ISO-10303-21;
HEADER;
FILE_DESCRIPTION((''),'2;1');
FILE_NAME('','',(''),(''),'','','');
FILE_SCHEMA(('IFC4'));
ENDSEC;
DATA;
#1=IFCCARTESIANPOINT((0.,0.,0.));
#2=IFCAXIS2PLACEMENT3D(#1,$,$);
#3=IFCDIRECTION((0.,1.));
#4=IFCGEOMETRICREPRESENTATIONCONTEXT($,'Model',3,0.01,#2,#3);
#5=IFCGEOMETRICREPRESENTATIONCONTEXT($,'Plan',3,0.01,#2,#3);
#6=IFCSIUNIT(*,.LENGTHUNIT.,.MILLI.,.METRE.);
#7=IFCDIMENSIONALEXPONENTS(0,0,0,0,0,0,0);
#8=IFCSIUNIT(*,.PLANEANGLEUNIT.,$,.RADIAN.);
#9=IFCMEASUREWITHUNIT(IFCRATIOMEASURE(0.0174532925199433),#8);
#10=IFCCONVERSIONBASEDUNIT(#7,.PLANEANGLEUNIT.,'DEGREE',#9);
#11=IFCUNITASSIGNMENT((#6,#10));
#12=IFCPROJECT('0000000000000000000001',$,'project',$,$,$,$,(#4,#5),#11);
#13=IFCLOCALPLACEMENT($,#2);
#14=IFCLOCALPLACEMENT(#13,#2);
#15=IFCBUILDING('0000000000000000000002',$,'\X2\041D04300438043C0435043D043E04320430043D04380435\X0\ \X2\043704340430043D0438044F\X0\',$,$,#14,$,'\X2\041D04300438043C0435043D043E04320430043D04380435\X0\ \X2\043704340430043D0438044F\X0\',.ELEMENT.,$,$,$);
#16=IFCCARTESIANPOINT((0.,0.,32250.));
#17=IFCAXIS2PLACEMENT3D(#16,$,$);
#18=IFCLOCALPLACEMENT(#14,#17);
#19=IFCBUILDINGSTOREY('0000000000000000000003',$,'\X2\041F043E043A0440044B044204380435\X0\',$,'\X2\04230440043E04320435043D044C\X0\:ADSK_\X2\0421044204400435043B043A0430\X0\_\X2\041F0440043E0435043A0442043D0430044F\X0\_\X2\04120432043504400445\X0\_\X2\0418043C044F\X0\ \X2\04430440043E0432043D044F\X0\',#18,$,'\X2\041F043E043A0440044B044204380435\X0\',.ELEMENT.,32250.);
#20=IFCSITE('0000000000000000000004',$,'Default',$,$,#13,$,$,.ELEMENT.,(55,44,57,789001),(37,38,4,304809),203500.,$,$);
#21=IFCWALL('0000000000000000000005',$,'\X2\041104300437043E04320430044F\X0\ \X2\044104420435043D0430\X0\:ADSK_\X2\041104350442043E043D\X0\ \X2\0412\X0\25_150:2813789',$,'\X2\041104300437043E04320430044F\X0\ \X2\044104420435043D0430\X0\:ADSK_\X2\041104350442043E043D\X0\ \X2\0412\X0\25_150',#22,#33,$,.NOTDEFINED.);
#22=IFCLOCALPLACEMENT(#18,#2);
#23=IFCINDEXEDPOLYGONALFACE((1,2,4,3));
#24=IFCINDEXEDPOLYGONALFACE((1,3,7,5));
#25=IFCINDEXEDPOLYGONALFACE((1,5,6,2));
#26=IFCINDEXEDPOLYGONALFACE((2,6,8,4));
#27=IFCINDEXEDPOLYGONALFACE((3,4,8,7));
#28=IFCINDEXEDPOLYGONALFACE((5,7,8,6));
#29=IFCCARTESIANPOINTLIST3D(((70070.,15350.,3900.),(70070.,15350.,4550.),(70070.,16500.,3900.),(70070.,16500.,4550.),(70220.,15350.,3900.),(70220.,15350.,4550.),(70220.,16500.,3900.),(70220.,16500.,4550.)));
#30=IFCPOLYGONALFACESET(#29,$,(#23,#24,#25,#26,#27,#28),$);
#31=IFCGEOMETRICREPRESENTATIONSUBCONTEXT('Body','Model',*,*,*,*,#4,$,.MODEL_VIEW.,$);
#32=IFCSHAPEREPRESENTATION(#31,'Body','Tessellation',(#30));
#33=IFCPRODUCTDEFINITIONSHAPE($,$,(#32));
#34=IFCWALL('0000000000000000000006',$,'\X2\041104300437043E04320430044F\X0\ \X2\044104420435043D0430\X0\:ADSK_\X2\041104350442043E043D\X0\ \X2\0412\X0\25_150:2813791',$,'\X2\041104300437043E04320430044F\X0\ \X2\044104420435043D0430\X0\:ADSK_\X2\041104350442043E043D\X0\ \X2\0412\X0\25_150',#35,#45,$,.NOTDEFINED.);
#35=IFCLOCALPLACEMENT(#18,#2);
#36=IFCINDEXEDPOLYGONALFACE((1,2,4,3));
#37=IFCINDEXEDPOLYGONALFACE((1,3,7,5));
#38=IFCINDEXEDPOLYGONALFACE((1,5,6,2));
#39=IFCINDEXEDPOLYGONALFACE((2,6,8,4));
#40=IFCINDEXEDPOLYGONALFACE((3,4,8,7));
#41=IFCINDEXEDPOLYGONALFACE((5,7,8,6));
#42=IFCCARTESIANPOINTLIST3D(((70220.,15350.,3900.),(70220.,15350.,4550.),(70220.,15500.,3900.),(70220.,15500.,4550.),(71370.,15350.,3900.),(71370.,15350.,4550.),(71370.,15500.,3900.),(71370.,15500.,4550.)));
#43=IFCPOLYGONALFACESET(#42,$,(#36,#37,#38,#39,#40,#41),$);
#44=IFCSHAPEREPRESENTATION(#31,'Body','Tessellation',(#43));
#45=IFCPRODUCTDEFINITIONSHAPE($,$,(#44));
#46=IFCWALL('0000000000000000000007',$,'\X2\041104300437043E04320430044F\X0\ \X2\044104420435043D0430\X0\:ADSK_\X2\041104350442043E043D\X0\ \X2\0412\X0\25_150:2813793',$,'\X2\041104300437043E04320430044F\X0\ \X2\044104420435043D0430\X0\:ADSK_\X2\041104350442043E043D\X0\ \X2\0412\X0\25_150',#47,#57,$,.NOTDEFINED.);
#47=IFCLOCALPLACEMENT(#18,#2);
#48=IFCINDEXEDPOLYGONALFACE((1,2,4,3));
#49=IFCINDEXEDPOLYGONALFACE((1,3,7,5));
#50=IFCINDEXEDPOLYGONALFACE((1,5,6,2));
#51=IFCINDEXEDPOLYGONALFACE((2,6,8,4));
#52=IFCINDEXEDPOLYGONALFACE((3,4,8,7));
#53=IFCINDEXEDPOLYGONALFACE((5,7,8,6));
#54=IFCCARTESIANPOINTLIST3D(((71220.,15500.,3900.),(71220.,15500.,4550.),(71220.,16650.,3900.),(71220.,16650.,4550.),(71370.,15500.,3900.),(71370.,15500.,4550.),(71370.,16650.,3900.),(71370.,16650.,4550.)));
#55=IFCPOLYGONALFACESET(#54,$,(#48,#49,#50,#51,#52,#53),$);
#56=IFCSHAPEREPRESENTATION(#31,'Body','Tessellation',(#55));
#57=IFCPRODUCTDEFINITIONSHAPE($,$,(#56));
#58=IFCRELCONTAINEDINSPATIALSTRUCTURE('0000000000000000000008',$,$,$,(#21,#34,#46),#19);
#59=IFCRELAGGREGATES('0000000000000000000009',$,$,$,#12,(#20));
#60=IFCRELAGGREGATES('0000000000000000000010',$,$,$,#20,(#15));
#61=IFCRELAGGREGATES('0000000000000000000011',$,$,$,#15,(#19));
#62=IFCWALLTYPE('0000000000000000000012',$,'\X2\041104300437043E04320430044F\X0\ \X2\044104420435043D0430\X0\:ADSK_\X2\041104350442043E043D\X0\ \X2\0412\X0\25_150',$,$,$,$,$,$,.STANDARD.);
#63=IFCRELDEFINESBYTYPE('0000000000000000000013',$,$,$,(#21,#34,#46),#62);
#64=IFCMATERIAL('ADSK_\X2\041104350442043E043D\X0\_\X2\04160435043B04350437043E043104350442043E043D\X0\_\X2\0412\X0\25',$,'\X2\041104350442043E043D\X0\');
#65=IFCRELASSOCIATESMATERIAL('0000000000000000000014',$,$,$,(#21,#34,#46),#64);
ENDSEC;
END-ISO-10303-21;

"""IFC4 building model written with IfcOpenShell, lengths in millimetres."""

from ifc_helpers import new_model, entity, si_unit, converted_unit, direction, frame, origin, place, context, subcontext, project, spatial, indexed_curve, outline, extrude, material, type_object, element, save


model = new_model("IFC4")

# Units and contexts
model_context = context("Model", 3, precision=0.01, world=origin(), true_north=direction((0.0, 1.0)))
plan_context = context("Plan", 3, precision=0.01, world=origin(), true_north=direction((0.0, 1.0)))
body_context = subcontext(model_context, "Body", "Model", "MODEL_VIEW")
ifc_project = project(units=[si_unit("LENGTHUNIT", "METRE", prefix="MILLI"), converted_unit("PLANEANGLEUNIT", "DEGREE", entity("IfcRatioMeasure", 0.0174532925199433), si_unit("PLANEANGLEUNIT", "RADIAN"), dimensions=[0, 0, 0, 0, 0, 0, 0])], contexts=[model_context, plan_context])

# Site, building, storey
site_placement = place(None, origin())
site = spatial("IfcSite", under=ifc_project, at=site_placement, Name="Default", CompositionType="ELEMENT", RefLatitude=(55, 44, 57, 789001), RefLongitude=(37, 38, 4, 304809), RefElevation=203500.0)
building_placement = place(site_placement, origin())
building = spatial("IfcBuilding", under=site, at=building_placement, Name="Наименование здания", LongName="Наименование здания", CompositionType="ELEMENT")
storey_placement = place(building_placement, frame((0.0, 0.0, 32250.0)))
storey = spatial("IfcBuildingStorey", under=building, at=storey_placement, Name="Покрытие", ObjectType="Уровень:ADSK_Стрелка_Проектная_Вверх_Имя уровня", LongName="Покрытие", CompositionType="ELEMENT", Elevation=32250.0)

# Walls
ifc_material = material(Name="ADSK_Бетон_Железобетон_В25", Category="Бетон")
wall_type_1 = type_object("IfcWallType", Name="Базовая стена:ADSK_Бетон В25_150", PredefinedType="STANDARD")
wall_1_placement = place(storey_placement, frame((70145.0, 15350.0, 3900.0), z_axis=(0.0, 0.0, 1.0), x_axis=(0.0, 1.0, 0.0)))
element("IfcWall", 1, at=wall_1_placement, inside=storey, type_object=wall_type_1, material=ifc_material, Name="Базовая стена:ADSK_Бетон В25_150:2813789", ObjectType="Базовая стена:ADSK_Бетон В25_150", PredefinedType="NOTDEFINED", context=body_context, shape_type="SweptSolid", body=[
    extrude(outline(indexed_curve([(1150.0, 75.0), (0.0, 75.0), (0.0, -75.0), (1150.0, -75.0), (1150.0, 75.0)], self_intersect=False)), origin(), (0.0, 0.0, 1.0), 650.0),
])
wall_2_placement = place(storey_placement, frame((71370.0, 15425.0, 3900.0), z_axis=(0.0, 0.0, 1.0), x_axis=(-1.0, 0.0, 0.0)))
element("IfcWall", 2, at=wall_2_placement, inside=storey, type_object=wall_type_1, material=ifc_material, Name="Базовая стена:ADSK_Бетон В25_150:2813791", ObjectType="Базовая стена:ADSK_Бетон В25_150", PredefinedType="NOTDEFINED", context=body_context, shape_type="SweptSolid", body=[
    extrude(outline(indexed_curve([(1150.0, 75.0), (0.0, 75.0), (0.0, -75.0), (1150.0, -75.0), (1150.0, 75.0)], self_intersect=False)), origin(), (0.0, 0.0, 1.0), 650.0),
])
wall_3_placement = place(storey_placement, frame((71295.0, 16650.0, 3900.0), z_axis=(0.0, 0.0, 1.0), x_axis=(0.0, -1.0, 0.0)))
element("IfcWall", 3, at=wall_3_placement, inside=storey, type_object=wall_type_1, material=ifc_material, Name="Базовая стена:ADSK_Бетон В25_150:2813793", ObjectType="Базовая стена:ADSK_Бетон В25_150", PredefinedType="NOTDEFINED", context=body_context, shape_type="SweptSolid", body=[
    extrude(outline(indexed_curve([(1150.0, 75.0), (0.0, 75.0), (0.0, -75.0), (1150.0, -75.0), (1150.0, 75.0)], self_intersect=False)), origin(), (0.0, 0.0, 1.0), 650.0),
])

save(model, "model.ifc")
